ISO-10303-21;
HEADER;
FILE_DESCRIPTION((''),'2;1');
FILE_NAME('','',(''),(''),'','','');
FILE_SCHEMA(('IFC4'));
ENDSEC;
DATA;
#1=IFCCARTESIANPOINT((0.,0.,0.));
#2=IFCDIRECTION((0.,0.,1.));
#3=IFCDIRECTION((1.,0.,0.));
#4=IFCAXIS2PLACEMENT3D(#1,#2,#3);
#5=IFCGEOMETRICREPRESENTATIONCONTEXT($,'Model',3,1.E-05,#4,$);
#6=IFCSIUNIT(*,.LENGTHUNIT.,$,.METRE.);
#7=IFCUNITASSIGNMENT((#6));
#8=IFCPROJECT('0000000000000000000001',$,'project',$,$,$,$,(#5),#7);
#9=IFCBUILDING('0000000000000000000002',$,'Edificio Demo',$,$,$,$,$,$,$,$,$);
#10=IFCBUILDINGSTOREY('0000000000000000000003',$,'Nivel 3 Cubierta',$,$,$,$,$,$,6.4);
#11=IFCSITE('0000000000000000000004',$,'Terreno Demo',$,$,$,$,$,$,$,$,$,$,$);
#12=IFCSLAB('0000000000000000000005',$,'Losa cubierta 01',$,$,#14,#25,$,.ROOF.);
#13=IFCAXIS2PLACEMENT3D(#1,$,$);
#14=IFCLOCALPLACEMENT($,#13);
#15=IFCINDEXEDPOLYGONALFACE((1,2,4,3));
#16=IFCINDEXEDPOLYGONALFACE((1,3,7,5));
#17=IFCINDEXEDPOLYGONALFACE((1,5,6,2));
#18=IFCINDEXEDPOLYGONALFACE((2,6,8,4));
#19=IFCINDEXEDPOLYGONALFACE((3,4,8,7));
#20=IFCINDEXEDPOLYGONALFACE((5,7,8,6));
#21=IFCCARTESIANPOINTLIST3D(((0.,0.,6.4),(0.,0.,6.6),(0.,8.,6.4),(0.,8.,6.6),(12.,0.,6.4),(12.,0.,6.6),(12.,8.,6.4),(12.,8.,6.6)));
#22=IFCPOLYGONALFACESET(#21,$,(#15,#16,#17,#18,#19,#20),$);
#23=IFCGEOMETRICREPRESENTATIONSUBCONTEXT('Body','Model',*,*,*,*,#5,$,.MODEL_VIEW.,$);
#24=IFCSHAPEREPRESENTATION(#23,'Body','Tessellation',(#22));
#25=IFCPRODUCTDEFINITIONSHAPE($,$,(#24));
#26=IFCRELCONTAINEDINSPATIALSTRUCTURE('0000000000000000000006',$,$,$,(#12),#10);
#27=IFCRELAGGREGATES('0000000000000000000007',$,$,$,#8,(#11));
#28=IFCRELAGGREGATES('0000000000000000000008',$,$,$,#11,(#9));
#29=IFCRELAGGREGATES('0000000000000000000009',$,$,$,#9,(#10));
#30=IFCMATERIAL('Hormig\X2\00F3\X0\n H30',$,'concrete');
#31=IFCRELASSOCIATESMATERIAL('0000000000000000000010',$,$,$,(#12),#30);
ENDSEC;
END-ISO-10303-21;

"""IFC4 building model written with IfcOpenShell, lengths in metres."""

from ifc_helpers import new_model, si_unit, frame, frame_2d, origin_with_axes, place, context, subcontext, project, spatial, rectangle, extrude, material, element, save


model = new_model("IFC4")

# Units and contexts
model_context = context("Model", 3, precision=1e-05, world=origin_with_axes())
body_context = subcontext(model_context, "Body", "Model", "MODEL_VIEW")
ifc_project = project(units=[si_unit("LENGTHUNIT", "METRE")], contexts=[model_context])

# Site, building, storey
site = spatial("IfcSite", under=ifc_project, Name="Terreno Demo")
building = spatial("IfcBuilding", under=site, Name="Edificio Demo")
storey = spatial("IfcBuildingStorey", under=building, Name="Nivel 3 Cubierta", Elevation=6.4)

# Slab
ifc_material = material(Name="Hormigón H30", Category="concrete")
slab_placement = place(None, frame((0.0, 0.0, 6.4), z_axis=(0.0, 0.0, 1.0), x_axis=(1.0, 0.0, 0.0)))
element("IfcSlab", 1, at=slab_placement, inside=storey, material=ifc_material, Name="Losa cubierta 01", PredefinedType="ROOF", context=body_context, shape_type="SweptSolid", body=[
    extrude(rectangle(XDim=12.0, YDim=8.0, at=frame_2d((6.0, 4.0))), origin_with_axes(), (0.0, 0.0, 1.0), 0.2),
])

save(model, "model.ifc")
